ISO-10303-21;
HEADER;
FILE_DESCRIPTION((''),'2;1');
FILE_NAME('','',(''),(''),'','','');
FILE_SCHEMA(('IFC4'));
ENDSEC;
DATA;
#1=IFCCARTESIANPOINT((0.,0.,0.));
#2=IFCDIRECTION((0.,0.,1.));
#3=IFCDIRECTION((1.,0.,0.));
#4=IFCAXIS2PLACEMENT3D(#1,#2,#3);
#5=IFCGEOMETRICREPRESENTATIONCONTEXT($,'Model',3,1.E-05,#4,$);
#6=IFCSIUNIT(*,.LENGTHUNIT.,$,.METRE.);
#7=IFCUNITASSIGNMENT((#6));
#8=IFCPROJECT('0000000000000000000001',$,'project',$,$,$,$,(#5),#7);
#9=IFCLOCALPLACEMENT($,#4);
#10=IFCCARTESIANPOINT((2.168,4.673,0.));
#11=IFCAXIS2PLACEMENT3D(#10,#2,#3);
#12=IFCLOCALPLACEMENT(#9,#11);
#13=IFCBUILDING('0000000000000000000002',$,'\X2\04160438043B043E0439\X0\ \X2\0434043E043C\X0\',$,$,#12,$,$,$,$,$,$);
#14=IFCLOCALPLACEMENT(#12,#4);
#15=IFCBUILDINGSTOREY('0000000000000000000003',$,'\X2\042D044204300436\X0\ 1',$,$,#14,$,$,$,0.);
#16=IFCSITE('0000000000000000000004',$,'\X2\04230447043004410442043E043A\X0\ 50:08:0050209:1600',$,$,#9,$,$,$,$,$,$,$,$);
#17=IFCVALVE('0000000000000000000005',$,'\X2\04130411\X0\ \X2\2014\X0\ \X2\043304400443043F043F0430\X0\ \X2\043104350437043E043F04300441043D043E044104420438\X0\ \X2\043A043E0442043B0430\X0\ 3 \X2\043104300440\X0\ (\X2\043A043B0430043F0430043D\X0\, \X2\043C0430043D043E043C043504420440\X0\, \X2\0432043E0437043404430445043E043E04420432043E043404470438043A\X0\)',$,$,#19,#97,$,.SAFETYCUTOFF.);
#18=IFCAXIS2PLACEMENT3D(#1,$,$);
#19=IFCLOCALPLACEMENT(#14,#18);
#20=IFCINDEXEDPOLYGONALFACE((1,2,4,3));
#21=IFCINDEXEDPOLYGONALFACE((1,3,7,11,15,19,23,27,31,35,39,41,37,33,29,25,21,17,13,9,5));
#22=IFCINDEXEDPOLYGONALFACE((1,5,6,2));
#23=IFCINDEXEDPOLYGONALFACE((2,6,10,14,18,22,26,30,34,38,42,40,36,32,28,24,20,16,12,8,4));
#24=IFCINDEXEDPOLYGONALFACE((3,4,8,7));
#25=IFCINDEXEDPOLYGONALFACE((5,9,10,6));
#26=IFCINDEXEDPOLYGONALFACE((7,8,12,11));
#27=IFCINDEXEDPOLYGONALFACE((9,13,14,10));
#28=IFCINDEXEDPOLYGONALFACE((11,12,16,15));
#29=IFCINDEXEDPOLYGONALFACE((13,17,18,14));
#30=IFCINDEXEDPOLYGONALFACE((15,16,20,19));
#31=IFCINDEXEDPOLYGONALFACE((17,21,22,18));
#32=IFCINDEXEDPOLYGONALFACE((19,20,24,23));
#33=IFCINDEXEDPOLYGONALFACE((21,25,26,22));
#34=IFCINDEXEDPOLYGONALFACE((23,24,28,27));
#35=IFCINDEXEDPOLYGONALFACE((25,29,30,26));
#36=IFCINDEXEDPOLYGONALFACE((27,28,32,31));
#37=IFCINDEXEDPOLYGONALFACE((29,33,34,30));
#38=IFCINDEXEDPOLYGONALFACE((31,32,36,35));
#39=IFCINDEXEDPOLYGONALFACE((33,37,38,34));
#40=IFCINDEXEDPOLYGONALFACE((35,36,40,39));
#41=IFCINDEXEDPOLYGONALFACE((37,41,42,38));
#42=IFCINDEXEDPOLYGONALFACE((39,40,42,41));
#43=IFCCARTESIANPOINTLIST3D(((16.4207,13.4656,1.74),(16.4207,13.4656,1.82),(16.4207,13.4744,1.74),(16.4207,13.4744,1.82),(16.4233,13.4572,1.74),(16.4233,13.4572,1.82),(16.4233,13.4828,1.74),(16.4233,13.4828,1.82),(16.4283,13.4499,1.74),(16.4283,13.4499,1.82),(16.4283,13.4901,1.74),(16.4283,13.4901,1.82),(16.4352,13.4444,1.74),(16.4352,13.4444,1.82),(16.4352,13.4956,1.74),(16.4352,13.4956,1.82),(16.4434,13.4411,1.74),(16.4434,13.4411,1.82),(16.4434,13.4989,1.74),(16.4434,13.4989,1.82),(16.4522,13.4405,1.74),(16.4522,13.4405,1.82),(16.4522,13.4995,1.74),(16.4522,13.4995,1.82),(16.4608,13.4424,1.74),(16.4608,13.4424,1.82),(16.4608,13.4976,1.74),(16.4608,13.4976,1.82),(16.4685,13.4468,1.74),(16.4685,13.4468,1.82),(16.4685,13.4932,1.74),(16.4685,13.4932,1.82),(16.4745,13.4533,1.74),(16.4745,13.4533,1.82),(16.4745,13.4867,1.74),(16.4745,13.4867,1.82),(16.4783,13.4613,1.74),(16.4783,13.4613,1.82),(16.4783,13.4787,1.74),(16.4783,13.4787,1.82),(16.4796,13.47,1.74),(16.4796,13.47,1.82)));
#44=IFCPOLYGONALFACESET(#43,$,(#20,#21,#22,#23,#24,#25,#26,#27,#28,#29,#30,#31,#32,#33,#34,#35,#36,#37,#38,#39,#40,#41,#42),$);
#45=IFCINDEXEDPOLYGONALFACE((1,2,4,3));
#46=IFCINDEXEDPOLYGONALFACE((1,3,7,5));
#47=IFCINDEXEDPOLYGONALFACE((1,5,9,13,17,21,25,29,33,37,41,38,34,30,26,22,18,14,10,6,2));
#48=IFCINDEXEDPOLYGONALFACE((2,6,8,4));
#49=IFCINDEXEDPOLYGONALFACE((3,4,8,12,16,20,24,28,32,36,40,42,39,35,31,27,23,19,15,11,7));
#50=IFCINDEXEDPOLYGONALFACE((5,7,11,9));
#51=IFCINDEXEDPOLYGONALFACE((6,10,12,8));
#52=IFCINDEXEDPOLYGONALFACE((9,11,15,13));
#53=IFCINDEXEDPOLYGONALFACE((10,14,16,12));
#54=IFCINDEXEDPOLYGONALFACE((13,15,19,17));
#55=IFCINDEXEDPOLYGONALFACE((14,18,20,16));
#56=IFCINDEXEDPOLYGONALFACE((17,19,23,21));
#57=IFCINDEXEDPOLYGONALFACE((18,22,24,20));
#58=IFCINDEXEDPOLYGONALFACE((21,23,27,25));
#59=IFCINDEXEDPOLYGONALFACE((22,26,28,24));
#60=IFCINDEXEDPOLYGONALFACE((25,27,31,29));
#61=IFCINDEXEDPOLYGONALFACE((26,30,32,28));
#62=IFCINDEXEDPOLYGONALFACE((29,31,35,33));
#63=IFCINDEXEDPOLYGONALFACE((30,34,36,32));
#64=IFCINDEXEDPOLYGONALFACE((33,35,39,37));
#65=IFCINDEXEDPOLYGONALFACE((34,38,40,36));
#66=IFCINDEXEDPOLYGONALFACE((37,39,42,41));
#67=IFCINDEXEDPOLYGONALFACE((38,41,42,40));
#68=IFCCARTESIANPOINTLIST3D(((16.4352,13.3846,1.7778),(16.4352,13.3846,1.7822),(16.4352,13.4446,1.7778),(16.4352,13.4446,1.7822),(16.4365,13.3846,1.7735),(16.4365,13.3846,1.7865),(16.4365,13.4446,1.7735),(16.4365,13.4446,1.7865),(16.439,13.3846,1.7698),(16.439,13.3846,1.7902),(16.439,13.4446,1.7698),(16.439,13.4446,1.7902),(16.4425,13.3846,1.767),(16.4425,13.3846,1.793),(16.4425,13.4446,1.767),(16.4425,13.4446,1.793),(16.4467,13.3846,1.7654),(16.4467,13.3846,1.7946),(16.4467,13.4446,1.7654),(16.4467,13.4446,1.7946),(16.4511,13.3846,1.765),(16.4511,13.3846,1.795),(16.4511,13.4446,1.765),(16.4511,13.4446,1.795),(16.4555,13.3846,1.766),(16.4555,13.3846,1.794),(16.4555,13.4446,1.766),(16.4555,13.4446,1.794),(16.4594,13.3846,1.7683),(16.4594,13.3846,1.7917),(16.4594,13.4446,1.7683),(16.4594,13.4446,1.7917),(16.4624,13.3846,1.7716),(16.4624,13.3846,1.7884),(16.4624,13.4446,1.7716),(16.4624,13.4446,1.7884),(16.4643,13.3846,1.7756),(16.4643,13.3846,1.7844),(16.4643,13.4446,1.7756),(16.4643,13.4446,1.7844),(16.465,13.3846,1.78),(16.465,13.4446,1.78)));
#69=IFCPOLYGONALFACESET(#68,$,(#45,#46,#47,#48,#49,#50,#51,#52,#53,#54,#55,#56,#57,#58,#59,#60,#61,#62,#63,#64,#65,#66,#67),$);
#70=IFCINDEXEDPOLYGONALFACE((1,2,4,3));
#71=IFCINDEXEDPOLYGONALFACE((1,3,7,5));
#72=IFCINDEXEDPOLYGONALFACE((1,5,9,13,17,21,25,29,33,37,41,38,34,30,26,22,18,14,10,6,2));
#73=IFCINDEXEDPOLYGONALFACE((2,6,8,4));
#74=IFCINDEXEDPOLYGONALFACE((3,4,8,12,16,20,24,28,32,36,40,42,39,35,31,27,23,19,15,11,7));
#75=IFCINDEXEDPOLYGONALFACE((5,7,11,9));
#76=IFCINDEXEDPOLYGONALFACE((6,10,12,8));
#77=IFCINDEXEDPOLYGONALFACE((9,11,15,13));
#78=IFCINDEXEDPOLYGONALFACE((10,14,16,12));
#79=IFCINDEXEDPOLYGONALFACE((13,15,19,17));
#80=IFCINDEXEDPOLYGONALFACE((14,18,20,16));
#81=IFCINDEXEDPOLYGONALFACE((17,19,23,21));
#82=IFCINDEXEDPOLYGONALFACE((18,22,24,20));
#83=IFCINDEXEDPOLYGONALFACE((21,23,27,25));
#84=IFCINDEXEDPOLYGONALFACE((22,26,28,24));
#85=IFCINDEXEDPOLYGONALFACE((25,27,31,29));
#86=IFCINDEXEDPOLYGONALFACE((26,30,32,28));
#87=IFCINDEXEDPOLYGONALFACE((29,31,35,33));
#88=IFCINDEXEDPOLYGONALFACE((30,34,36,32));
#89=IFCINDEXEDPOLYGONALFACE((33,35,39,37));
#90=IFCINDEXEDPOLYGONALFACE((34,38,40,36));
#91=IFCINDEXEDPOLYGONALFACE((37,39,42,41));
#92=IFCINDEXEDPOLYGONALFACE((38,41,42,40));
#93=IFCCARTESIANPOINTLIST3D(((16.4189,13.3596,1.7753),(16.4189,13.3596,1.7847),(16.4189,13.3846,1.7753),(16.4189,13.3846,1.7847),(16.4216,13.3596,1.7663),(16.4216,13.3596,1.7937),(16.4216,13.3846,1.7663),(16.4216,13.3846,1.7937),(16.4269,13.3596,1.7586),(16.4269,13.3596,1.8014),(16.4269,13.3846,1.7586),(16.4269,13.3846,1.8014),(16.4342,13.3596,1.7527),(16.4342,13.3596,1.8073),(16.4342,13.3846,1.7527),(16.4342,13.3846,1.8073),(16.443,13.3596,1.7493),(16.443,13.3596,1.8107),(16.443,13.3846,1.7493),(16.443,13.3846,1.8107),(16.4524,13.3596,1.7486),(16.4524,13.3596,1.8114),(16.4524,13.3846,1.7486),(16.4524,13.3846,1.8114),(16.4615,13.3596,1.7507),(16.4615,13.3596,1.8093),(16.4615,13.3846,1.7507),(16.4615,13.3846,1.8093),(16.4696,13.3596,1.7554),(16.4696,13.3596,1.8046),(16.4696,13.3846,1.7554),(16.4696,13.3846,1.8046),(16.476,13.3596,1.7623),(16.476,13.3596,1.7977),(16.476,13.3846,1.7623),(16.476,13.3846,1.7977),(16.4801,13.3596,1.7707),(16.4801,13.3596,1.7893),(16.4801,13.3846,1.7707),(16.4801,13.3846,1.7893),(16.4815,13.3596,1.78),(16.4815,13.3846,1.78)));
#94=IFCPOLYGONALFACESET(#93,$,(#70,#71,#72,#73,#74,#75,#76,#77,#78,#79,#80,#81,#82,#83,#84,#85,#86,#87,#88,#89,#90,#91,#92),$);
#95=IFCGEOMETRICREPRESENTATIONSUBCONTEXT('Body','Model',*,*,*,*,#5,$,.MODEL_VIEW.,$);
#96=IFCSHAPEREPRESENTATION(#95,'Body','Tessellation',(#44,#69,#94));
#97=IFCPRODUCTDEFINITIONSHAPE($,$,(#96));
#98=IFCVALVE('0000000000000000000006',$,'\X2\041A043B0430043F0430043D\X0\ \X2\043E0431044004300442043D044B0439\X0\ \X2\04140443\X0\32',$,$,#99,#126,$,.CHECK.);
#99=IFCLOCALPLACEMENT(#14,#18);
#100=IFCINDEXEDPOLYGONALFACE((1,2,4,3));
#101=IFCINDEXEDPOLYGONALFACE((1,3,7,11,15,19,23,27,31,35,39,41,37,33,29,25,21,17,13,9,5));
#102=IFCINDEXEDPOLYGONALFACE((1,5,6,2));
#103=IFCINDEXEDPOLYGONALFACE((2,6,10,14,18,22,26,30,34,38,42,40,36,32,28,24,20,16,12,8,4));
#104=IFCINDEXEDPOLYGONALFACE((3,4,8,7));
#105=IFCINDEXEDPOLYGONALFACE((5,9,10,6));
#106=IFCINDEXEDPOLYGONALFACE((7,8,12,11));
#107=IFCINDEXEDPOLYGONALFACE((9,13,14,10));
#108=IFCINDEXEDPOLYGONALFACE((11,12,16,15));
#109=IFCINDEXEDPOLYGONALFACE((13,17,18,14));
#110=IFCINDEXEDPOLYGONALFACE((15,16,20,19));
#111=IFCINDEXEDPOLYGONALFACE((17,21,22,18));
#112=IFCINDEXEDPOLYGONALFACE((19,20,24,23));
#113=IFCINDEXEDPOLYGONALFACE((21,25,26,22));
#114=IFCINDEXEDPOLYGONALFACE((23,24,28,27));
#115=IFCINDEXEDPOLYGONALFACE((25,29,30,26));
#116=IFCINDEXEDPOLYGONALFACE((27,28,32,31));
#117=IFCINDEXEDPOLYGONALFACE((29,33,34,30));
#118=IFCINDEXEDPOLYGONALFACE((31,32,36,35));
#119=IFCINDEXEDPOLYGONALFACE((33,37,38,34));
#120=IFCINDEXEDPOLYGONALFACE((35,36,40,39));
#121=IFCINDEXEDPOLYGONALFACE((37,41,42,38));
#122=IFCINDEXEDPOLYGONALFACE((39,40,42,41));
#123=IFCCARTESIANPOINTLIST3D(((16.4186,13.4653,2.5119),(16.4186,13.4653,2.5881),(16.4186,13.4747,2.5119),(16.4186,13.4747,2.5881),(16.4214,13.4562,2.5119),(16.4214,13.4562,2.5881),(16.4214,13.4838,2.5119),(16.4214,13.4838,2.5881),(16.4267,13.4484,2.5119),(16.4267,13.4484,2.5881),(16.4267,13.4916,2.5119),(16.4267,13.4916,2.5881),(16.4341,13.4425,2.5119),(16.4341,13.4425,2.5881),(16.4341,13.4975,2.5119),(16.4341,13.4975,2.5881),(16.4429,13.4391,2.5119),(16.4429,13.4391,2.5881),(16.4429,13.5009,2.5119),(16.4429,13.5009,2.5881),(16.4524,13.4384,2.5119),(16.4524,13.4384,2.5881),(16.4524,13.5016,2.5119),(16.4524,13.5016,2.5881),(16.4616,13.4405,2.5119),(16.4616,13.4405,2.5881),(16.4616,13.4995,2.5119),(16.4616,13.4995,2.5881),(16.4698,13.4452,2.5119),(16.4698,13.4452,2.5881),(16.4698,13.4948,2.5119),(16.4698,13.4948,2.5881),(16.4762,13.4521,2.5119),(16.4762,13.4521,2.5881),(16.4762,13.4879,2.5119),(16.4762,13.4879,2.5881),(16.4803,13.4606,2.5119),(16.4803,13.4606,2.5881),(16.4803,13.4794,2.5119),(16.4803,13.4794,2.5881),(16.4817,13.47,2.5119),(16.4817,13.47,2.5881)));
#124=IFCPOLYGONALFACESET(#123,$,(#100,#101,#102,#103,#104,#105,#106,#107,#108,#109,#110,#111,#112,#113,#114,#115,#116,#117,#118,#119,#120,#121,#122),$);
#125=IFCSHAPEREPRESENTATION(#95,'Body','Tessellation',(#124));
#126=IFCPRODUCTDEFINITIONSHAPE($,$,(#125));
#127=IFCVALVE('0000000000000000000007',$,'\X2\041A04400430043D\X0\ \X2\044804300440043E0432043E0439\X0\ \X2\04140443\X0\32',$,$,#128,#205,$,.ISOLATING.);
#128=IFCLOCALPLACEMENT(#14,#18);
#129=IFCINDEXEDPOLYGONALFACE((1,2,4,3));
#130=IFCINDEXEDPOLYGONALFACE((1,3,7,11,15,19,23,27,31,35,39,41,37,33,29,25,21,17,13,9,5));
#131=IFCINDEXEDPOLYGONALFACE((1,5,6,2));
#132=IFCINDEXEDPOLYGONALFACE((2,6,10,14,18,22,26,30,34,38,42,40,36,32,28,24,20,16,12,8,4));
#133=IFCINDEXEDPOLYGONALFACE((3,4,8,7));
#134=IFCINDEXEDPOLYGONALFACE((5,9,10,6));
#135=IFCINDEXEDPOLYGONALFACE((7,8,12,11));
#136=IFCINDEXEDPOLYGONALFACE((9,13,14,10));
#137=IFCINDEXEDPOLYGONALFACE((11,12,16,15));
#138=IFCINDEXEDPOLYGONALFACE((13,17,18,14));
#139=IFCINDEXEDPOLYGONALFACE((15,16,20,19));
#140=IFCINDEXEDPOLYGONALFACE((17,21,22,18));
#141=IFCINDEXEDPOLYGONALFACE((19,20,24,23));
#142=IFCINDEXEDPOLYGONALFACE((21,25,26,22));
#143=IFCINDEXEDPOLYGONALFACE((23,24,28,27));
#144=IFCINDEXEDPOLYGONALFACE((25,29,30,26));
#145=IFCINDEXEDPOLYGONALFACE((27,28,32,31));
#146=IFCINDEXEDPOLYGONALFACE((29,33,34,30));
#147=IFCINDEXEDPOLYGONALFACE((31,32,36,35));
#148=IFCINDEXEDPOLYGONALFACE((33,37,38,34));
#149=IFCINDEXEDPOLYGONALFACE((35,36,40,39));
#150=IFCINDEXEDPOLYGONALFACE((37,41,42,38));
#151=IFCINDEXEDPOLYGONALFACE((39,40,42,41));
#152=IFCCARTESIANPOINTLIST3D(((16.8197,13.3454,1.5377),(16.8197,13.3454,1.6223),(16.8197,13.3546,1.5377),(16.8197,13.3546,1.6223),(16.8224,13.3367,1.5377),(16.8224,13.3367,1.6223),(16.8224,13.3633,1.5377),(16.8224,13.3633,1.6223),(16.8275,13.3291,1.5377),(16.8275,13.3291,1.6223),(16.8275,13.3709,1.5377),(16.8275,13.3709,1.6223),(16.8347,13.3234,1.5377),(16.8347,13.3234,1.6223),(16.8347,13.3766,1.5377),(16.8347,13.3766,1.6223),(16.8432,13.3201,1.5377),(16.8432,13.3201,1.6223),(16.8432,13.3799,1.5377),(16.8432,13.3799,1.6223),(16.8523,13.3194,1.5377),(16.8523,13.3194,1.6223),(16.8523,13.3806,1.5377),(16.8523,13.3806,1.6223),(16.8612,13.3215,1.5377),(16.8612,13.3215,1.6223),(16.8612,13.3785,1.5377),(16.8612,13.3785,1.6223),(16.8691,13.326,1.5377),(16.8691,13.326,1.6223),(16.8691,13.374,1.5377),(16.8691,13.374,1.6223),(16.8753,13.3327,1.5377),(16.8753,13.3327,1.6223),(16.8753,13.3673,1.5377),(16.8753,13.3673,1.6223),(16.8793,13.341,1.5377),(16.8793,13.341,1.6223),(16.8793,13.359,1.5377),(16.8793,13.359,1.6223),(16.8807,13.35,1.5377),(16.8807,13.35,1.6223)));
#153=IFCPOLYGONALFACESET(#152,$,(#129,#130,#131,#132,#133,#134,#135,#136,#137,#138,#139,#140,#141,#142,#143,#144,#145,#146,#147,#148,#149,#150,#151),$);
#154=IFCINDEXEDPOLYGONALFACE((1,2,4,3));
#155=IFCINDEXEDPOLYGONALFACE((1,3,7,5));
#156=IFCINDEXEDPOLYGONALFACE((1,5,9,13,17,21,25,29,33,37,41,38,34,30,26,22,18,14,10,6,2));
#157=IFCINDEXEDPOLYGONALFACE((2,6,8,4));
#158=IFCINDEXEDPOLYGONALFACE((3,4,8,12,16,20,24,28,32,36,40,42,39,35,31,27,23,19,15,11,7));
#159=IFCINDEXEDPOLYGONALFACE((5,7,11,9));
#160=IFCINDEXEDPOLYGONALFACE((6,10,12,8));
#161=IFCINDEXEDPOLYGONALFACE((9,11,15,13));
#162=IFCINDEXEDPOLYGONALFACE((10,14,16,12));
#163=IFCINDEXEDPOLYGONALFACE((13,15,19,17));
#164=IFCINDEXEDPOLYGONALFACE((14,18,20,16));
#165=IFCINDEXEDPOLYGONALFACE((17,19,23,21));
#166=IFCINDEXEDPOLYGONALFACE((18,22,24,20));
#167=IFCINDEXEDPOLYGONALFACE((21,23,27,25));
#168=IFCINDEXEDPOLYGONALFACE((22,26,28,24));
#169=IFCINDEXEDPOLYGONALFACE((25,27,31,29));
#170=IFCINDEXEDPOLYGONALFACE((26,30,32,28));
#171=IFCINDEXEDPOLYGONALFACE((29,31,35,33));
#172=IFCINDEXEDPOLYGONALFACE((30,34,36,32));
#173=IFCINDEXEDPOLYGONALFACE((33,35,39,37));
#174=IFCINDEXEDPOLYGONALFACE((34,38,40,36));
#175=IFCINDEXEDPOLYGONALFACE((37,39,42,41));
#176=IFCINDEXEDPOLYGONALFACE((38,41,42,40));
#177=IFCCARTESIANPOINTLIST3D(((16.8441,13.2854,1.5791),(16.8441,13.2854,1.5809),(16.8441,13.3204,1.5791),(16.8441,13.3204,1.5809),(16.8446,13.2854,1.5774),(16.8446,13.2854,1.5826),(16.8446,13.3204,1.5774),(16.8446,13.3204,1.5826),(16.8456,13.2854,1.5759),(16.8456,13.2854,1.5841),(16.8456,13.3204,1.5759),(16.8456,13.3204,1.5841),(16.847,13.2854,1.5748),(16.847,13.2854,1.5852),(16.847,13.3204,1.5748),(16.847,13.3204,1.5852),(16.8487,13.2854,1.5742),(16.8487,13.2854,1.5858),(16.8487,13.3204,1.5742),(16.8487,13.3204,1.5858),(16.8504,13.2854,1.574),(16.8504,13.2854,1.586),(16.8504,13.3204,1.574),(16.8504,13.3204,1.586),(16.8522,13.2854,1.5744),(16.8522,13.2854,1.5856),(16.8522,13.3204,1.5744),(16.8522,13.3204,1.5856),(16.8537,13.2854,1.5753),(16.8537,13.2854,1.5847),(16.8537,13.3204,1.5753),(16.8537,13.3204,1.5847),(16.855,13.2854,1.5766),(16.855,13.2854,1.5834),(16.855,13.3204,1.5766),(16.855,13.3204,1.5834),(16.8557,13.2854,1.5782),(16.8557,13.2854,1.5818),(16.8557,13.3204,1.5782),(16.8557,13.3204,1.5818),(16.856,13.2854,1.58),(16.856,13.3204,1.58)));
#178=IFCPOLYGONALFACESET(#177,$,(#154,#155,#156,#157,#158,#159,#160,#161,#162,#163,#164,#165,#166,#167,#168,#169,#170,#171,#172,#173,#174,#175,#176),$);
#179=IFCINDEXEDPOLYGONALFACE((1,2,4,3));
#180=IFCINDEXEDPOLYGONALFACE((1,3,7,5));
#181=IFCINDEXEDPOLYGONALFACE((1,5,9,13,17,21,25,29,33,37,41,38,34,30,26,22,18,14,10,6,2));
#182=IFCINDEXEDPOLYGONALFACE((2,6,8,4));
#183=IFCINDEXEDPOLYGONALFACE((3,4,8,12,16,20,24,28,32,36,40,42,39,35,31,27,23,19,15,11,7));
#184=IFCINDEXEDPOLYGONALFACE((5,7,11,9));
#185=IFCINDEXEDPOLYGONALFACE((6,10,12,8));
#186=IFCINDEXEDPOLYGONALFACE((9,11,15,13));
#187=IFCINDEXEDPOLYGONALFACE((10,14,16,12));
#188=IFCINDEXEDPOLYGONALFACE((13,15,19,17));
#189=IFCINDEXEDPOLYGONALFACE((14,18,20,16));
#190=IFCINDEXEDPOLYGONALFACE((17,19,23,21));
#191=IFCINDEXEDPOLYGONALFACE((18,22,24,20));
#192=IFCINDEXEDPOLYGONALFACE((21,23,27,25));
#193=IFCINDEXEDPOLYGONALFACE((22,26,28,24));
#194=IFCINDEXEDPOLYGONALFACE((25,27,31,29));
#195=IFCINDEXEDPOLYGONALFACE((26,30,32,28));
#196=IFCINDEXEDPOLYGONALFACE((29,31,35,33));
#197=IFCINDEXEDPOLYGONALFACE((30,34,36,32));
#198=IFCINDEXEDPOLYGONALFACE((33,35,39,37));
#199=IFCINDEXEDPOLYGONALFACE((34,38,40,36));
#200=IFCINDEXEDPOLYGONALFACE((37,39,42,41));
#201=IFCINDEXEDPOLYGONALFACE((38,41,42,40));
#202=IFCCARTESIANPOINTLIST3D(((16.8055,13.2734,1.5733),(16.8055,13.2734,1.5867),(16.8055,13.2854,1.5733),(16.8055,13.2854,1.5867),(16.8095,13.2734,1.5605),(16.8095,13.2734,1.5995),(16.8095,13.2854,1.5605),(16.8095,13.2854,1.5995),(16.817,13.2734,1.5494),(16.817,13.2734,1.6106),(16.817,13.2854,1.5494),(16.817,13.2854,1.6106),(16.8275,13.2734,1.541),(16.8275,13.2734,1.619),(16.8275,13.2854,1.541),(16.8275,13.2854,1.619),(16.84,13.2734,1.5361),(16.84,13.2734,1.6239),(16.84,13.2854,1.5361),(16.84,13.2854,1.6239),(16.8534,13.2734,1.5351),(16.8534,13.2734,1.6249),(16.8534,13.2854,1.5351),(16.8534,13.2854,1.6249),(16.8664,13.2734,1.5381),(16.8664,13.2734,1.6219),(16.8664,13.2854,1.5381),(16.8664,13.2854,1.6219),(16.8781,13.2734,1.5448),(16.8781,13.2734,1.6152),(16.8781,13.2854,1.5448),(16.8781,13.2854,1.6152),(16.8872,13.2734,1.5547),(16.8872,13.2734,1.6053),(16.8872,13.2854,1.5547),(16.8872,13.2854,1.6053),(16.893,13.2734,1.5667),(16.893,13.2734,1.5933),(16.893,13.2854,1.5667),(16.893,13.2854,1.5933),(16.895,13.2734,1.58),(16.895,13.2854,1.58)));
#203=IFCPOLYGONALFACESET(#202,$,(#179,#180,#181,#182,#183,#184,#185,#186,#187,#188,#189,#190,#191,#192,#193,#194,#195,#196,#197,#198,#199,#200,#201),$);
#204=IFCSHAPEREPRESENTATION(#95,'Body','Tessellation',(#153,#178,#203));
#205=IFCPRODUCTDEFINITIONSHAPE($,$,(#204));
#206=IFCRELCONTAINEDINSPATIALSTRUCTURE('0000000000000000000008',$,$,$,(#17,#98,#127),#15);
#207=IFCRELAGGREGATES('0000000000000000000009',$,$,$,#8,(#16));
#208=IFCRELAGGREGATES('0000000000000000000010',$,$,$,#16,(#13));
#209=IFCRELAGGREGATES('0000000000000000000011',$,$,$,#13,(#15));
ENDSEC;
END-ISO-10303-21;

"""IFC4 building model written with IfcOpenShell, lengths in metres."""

from ifc_helpers import new_model, si_unit, frame, origin_with_axes, origin_2d, place, context, subcontext, project, spatial, circle, extrude, element, save


model = new_model("IFC4")

# Units and contexts
model_context = context("Model", 3, precision=1e-05, world=origin_with_axes())
body_context = subcontext(model_context, "Body", "Model", "MODEL_VIEW")
ifc_project = project(units=[si_unit("LENGTHUNIT", "METRE")], contexts=[model_context])

# Site, building, storey
site_placement = place(None, origin_with_axes())
site = spatial("IfcSite", under=ifc_project, at=site_placement, Name="Участок 50:08:0050209:1600")
building_placement = place(site_placement, frame((2.168, 4.673, 0.0), z_axis=(0.0, 0.0, 1.0), x_axis=(1.0, 0.0, 0.0)))
building = spatial("IfcBuilding", under=site, at=building_placement, Name="Жилой дом")
storey_placement = place(building_placement, origin_with_axes())
storey = spatial("IfcBuildingStorey", under=building, at=storey_placement, Name="Этаж 1", Elevation=0.0)

# Valves
valve_1_placement = place(storey_placement, origin_with_axes())
element("IfcValve", 1, at=valve_1_placement, inside=storey, Name="ГБ — группа безопасности котла 3 бар (клапан, манометр, воздухоотводчик)", PredefinedType="SAFETYCUTOFF", context=body_context, shape_type="SweptSolid", body=[
    extrude(circle(Radius=0.0296, at=origin_2d()), frame((16.45, 13.47, 1.74), z_axis=(0.0, 0.0, 1.0), x_axis=(1.0, 0.0, 0.0)), (0.0, 0.0, 1.0), 0.08),
    extrude(circle(Radius=0.015, at=origin_2d()), frame((16.45, 13.4446, 1.78), z_axis=(0.0, -1.0, 0.0), x_axis=(1.0, 0.0, 0.0)), (0.0, 0.0, 1.0), 0.06),
    extrude(circle(Radius=0.0315, at=origin_2d()), frame((16.45, 13.3846, 1.78), z_axis=(0.0, -1.0, 0.0), x_axis=(1.0, 0.0, 0.0)), (0.0, 0.0, 1.0), 0.025),
])
valve_2_placement = place(storey_placement, origin_with_axes())
element("IfcValve", 2, at=valve_2_placement, inside=storey, Name="Клапан обратный Ду32", PredefinedType="CHECK", context=body_context, shape_type="SweptSolid", body=[
    extrude(circle(Radius=0.0317, at=origin_2d()), frame((16.45, 13.47, 2.5119), z_axis=(0.0, 0.0, 1.0), x_axis=(1.0, 0.0, 0.0)), (0.0, 0.0, 1.0), 0.0761),
])
valve_3_placement = place(storey_placement, origin_with_axes())
element("IfcValve", 3, at=valve_3_placement, inside=storey, Name="Кран шаровой Ду32", PredefinedType="ISOLATING", context=body_context, shape_type="SweptSolid", body=[
    extrude(circle(Radius=0.0307, at=origin_2d()), frame((16.85, 13.35, 1.5377), z_axis=(0.0, 0.0, 1.0), x_axis=(1.0, 0.0, 0.0)), (0.0, 0.0, 1.0), 0.0846),
    extrude(circle(Radius=0.006, at=origin_2d()), frame((16.85, 13.3204, 1.58), z_axis=(0.0, -1.0, 0.0), x_axis=(1.0, 0.0, 0.0)), (0.0, 0.0, 1.0), 0.035),
    extrude(circle(Radius=0.045, at=origin_2d()), frame((16.85, 13.2854, 1.58), z_axis=(0.0, -1.0, 0.0), x_axis=(1.0, 0.0, 0.0)), (0.0, 0.0, 1.0), 0.012),
])

save(model, "model.ifc")
